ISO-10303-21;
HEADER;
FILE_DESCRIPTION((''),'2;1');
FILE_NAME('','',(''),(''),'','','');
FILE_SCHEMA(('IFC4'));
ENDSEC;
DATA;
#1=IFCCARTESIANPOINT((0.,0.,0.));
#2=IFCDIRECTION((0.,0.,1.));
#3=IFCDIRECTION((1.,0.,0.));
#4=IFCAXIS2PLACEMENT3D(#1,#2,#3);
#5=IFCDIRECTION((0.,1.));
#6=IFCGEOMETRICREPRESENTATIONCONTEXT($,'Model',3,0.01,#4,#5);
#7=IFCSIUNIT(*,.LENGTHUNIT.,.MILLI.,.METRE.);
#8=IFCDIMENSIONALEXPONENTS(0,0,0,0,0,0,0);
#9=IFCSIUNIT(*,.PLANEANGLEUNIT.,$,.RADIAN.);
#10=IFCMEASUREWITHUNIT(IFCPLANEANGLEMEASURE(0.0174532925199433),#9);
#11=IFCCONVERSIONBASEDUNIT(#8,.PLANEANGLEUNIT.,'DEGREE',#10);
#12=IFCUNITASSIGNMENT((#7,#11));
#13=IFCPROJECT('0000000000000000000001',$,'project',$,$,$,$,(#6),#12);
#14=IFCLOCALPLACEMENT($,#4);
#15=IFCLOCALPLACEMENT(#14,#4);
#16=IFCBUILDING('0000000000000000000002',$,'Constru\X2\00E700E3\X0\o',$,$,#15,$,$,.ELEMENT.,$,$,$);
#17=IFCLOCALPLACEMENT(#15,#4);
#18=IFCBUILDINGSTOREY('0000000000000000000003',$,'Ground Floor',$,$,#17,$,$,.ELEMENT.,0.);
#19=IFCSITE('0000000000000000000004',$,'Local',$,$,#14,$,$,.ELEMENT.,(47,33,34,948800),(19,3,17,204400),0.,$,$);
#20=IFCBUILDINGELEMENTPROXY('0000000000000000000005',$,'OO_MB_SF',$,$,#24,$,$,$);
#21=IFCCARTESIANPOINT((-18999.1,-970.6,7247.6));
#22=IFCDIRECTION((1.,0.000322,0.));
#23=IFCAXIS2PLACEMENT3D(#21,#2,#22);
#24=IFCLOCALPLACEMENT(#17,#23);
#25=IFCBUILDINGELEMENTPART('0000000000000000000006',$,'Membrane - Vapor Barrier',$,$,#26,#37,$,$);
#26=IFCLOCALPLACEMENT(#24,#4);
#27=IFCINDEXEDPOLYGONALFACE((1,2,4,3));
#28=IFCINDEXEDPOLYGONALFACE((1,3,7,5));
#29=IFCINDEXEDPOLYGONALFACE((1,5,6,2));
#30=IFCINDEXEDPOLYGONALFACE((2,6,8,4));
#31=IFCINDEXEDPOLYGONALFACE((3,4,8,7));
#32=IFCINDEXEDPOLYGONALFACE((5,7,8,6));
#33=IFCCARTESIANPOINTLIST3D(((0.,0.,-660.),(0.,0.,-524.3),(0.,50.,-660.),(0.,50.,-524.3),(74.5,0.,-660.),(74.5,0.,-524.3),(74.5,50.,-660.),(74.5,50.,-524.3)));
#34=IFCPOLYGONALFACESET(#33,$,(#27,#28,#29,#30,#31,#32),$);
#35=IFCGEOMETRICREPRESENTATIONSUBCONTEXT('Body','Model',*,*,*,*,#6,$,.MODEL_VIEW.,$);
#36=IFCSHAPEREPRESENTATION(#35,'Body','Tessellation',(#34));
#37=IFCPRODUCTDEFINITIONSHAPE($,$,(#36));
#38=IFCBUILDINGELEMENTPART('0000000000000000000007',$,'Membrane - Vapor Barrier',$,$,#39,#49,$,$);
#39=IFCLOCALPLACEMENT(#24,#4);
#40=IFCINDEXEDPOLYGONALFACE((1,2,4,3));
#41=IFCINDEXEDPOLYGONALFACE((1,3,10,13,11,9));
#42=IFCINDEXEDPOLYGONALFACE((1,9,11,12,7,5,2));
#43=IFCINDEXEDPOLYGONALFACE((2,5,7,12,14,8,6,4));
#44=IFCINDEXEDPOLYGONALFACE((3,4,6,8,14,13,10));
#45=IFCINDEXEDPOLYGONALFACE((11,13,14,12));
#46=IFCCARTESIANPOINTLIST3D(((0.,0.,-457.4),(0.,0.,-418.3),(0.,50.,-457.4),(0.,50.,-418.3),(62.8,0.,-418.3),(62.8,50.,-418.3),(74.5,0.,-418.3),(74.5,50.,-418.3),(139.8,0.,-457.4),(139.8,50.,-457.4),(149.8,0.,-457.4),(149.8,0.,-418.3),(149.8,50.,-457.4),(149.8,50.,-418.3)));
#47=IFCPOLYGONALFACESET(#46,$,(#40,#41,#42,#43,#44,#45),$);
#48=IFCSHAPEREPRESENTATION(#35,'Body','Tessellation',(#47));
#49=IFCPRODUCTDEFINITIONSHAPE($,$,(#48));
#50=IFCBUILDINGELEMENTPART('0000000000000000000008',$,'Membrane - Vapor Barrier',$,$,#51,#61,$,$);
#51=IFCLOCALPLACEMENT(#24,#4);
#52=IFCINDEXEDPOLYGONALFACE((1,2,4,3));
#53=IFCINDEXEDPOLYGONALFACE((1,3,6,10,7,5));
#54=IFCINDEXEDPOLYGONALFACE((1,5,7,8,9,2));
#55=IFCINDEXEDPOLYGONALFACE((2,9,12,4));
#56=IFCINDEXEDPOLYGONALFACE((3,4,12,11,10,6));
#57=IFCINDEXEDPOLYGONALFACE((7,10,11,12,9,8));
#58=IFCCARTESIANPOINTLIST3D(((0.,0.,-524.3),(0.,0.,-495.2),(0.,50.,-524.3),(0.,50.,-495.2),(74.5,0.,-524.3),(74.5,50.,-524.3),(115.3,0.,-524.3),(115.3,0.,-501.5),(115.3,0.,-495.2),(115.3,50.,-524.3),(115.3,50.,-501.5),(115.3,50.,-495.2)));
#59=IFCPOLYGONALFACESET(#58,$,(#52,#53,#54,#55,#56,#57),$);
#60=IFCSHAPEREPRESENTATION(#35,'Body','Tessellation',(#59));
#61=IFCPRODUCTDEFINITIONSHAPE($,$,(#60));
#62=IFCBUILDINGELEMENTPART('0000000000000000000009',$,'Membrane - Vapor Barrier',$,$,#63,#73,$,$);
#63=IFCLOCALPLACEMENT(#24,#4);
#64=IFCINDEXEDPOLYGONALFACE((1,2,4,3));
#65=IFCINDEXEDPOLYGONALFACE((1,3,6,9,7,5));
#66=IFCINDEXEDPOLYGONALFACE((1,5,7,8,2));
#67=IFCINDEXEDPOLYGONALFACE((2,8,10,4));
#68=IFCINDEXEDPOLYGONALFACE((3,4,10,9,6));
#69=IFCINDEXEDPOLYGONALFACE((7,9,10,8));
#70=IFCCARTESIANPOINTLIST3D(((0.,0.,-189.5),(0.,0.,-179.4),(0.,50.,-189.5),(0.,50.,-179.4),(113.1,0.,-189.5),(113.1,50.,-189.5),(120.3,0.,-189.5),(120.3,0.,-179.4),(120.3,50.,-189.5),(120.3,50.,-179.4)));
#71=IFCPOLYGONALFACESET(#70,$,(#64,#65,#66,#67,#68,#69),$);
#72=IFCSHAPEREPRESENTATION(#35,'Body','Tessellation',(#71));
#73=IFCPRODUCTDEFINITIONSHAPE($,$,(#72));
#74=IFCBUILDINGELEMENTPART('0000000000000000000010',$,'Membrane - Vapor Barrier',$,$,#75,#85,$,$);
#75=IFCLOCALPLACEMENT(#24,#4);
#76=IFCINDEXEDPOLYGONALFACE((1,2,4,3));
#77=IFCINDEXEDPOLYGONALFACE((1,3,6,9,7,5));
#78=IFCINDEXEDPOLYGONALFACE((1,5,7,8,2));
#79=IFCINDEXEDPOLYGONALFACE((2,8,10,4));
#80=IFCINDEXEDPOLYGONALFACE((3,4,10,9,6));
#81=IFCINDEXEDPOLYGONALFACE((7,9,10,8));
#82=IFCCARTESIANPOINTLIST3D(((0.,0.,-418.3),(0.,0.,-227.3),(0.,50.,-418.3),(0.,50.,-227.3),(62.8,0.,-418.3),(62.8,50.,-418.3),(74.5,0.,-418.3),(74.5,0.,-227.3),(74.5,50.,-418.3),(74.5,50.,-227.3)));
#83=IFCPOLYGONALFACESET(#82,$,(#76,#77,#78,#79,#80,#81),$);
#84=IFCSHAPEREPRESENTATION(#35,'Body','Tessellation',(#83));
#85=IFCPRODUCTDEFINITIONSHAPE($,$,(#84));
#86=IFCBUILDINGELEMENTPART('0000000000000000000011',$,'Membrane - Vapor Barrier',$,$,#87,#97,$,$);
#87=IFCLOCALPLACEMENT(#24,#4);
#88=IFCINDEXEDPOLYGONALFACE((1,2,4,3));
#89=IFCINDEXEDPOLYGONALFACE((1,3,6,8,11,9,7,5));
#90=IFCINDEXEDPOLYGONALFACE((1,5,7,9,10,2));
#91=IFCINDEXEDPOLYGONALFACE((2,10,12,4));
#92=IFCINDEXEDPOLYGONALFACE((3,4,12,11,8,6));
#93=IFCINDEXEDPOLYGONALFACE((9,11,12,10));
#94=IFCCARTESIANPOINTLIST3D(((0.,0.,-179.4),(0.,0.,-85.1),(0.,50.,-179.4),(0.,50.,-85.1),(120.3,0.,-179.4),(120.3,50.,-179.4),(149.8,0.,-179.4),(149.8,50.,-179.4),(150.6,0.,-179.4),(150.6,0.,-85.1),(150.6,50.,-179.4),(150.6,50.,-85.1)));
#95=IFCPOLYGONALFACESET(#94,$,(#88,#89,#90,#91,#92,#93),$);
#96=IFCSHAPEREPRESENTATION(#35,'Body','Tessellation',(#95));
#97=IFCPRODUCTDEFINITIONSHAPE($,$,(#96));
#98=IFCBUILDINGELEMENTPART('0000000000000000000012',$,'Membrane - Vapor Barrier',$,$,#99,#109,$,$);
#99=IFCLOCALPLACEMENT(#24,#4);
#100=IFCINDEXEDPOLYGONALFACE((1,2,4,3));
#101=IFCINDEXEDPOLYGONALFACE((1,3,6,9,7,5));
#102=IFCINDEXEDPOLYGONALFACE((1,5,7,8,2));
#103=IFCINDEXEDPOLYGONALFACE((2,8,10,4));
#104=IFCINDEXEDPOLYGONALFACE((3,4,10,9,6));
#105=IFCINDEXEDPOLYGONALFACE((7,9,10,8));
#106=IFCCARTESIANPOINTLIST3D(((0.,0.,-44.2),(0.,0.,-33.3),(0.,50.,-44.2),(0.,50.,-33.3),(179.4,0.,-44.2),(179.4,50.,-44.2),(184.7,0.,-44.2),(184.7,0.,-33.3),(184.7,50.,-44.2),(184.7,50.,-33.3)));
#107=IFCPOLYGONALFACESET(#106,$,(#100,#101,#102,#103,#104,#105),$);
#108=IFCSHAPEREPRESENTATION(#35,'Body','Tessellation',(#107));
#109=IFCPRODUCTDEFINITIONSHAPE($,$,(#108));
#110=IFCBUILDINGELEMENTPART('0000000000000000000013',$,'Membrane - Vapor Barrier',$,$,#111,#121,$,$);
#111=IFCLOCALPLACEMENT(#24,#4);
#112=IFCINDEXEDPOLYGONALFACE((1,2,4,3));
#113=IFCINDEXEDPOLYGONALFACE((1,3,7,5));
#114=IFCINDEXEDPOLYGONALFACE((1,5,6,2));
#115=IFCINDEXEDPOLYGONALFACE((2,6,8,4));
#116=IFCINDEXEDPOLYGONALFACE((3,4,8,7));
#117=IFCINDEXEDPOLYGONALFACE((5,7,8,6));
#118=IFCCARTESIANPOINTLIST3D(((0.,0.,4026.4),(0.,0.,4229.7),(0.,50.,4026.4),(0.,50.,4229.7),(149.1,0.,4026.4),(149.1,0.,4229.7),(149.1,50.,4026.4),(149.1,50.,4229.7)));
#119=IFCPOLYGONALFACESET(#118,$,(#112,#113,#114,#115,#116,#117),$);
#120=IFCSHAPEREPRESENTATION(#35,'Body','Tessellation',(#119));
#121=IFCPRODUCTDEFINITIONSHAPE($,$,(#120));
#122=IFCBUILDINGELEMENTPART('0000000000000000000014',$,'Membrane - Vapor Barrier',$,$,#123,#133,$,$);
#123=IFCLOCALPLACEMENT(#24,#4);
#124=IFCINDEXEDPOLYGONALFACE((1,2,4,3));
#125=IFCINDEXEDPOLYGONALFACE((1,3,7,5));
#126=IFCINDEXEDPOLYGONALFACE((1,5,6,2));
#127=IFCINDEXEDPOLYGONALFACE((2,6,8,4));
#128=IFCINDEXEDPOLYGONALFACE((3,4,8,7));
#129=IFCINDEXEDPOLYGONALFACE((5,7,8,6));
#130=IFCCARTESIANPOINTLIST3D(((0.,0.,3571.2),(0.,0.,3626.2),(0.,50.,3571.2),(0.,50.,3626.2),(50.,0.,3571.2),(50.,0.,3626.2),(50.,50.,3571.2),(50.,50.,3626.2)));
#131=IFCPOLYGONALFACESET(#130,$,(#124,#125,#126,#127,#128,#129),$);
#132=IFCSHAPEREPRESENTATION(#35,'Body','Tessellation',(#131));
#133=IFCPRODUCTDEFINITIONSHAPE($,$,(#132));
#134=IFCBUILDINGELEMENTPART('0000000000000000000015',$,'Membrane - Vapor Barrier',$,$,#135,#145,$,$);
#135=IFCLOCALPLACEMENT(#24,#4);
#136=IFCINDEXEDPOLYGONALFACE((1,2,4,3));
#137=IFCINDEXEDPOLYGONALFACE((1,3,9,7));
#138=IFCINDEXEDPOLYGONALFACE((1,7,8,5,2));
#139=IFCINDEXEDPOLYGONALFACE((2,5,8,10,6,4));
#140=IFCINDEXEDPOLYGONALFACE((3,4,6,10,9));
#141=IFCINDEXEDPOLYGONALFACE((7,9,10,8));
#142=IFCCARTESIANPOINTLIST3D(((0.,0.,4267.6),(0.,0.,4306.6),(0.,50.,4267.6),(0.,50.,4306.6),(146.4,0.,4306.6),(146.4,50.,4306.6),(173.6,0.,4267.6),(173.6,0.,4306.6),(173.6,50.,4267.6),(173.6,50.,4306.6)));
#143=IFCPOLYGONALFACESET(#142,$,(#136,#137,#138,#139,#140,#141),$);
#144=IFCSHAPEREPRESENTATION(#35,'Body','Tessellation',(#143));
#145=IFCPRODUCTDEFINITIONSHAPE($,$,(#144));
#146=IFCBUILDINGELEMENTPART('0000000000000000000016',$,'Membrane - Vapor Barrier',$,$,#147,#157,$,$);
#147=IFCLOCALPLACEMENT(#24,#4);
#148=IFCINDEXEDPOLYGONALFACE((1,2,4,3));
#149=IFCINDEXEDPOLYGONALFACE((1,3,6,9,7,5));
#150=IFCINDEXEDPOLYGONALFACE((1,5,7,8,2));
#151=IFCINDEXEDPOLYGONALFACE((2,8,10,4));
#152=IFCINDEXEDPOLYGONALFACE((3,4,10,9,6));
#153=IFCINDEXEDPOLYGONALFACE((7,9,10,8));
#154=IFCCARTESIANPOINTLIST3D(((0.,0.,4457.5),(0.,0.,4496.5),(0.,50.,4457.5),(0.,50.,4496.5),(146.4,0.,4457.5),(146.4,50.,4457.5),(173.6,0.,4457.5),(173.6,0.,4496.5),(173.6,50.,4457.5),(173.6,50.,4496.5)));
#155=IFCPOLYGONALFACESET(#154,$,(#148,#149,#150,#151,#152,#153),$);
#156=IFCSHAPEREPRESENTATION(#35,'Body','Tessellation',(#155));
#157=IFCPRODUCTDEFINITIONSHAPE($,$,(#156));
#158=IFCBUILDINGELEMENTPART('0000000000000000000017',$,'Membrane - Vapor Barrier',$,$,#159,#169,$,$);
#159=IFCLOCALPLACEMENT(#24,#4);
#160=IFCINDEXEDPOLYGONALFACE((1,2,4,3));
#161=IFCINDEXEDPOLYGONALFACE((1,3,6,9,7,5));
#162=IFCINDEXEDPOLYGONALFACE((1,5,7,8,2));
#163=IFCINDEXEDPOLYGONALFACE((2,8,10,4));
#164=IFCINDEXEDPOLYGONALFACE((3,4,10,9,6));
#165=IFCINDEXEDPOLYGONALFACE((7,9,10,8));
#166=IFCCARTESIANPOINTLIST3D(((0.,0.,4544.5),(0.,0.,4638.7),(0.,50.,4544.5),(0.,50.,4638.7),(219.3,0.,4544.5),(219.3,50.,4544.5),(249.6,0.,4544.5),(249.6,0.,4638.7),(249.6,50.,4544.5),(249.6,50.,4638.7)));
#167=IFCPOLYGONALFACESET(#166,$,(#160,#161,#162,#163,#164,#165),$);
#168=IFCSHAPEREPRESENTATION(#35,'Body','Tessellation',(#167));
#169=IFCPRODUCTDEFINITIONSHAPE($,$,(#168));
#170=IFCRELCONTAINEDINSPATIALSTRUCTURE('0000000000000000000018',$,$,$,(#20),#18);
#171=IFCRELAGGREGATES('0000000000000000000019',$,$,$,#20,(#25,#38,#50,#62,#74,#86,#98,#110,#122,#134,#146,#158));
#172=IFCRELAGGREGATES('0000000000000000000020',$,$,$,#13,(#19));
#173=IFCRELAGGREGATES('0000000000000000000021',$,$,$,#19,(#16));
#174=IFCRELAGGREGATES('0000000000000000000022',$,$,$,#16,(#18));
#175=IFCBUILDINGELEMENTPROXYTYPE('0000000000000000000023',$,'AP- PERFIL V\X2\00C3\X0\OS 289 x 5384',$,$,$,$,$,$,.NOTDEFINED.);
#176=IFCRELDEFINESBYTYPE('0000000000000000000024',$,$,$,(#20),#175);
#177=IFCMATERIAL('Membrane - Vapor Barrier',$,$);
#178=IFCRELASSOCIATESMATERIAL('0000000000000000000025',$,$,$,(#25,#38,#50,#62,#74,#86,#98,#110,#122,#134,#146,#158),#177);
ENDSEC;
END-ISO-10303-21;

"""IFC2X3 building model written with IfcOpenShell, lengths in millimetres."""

from ifc_helpers import new_model, entity, si_unit, converted_unit, direction, frame, origin_with_axes, place, context, subcontext, project, spatial, polyline, outline, extrude, material, type_object, element, aggregate, save


model = new_model("IFC2X3")

# Units and contexts
model_context = context("Model", 3, precision=0.01, world=origin_with_axes(), true_north=direction((0.0, 1.0)))
body_context = subcontext(model_context, "Body", "Model", "MODEL_VIEW")
ifc_project = project(units=[si_unit("LENGTHUNIT", "METRE", prefix="MILLI"), converted_unit("PLANEANGLEUNIT", "DEGREE", entity("IfcPlaneAngleMeasure", 0.0174532925199433), si_unit("PLANEANGLEUNIT", "RADIAN"), dimensions=[0, 0, 0, 0, 0, 0, 0])], contexts=[model_context])

# Site, building, storey
site_placement = place(None, origin_with_axes())
site = spatial("IfcSite", under=ifc_project, at=site_placement, Name="Local", CompositionType="ELEMENT", RefLatitude=(47, 33, 34, 948800), RefLongitude=(19, 3, 17, 204400), RefElevation=0.0)
building_placement = place(site_placement, origin_with_axes())
building = spatial("IfcBuilding", under=site, at=building_placement, Name="Construção", CompositionType="ELEMENT")
storey_placement = place(building_placement, origin_with_axes())
storey = spatial("IfcBuildingStorey", under=building, at=storey_placement, Name="Ground Floor", CompositionType="ELEMENT", Elevation=0.0)

# Building element proxy, building element parts
building_element_proxy_type = type_object("IfcBuildingElementProxyType", Name="AP- PERFIL VÃOS 289 x 5384", PredefinedType="NOTDEFINED")
proxy_1_placement = place(storey_placement, frame((-18999.1, -970.6, 7247.6), z_axis=(0.0, 0.0, 1.0), x_axis=(1.0, 0.000322, 0.0)))
proxy_1 = element("IfcBuildingElementProxy", 1, at=proxy_1_placement, inside=storey, type_object=building_element_proxy_type, Name="OO_MB_SF")
ifc_material = material(Name="Membrane - Vapor Barrier")
building_element_part_1_placement = place(proxy_1_placement, origin_with_axes())
building_element_part_1 = element("IfcBuildingElementPart", 2, at=building_element_part_1_placement, material=ifc_material, Name="Membrane - Vapor Barrier", context=body_context, shape_type="SweptSolid", body=[
    extrude(outline(polyline([(0.0, -660.0), (74.5, -660.0), (74.5, -524.3), (0.0, -524.3), (0.0, -660.0)])), frame((0.0, 50.0, 0.0), z_axis=(0.0, -1.0, 0.0), x_axis=(1.0, 0.0, 0.0)), (0.0, 0.0, 1.0), 50.0),
])
building_element_part_2_placement = place(proxy_1_placement, origin_with_axes())
building_element_part_2 = element("IfcBuildingElementPart", 3, at=building_element_part_2_placement, material=ifc_material, Name="Membrane - Vapor Barrier", context=body_context, shape_type="SweptSolid", body=[
    extrude(outline(polyline([(62.8, -418.3), (0.0, -418.3), (0.0, -457.4), (139.8, -457.4), (149.8, -457.4), (149.8, -418.3), (74.5, -418.3), (62.8, -418.3)])), frame((0.0, 50.0, 0.0), z_axis=(0.0, -1.0, 0.0), x_axis=(1.0, 0.0, 0.0)), (0.0, 0.0, 1.0), 50.0),
])
building_element_part_3_placement = place(proxy_1_placement, origin_with_axes())
building_element_part_3 = element("IfcBuildingElementPart", 4, at=building_element_part_3_placement, material=ifc_material, Name="Membrane - Vapor Barrier", context=body_context, shape_type="SweptSolid", body=[
    extrude(outline(polyline([(0.0, -524.3), (74.5, -524.3), (115.3, -524.3), (115.3, -501.5), (115.3, -495.2), (0.0, -495.2), (0.0, -524.3)])), frame((0.0, 50.0, 0.0), z_axis=(0.0, -1.0, 0.0), x_axis=(1.0, 0.0, 0.0)), (0.0, 0.0, 1.0), 50.0),
])
building_element_part_4_placement = place(proxy_1_placement, origin_with_axes())
building_element_part_4 = element("IfcBuildingElementPart", 5, at=building_element_part_4_placement, material=ifc_material, Name="Membrane - Vapor Barrier", context=body_context, shape_type="SweptSolid", body=[
    extrude(outline(polyline([(120.3, -179.4), (0.0, -179.4), (0.0, -189.5), (113.1, -189.5), (120.3, -189.5), (120.3, -179.4)])), frame((0.0, 50.0, 0.0), z_axis=(0.0, -1.0, 0.0), x_axis=(1.0, 0.0, 0.0)), (0.0, 0.0, 1.0), 50.0),
])
building_element_part_5_placement = place(proxy_1_placement, origin_with_axes())
building_element_part_5 = element("IfcBuildingElementPart", 6, at=building_element_part_5_placement, material=ifc_material, Name="Membrane - Vapor Barrier", context=body_context, shape_type="SweptSolid", body=[
    extrude(outline(polyline([(0.0, -227.3), (0.0, -418.3), (62.8, -418.3), (74.5, -418.3), (74.5, -227.3), (0.0, -227.3)])), frame((0.0, 50.0, 0.0), z_axis=(0.0, -1.0, 0.0), x_axis=(1.0, 0.0, 0.0)), (0.0, 0.0, 1.0), 50.0),
])
building_element_part_6_placement = place(proxy_1_placement, origin_with_axes())
building_element_part_6 = element("IfcBuildingElementPart", 7, at=building_element_part_6_placement, material=ifc_material, Name="Membrane - Vapor Barrier", context=body_context, shape_type="SweptSolid", body=[
    extrude(outline(polyline([(0.0, -85.1), (0.0, -179.4), (120.3, -179.4), (149.8, -179.4), (150.6, -179.4), (150.6, -85.1), (0.0, -85.1)])), frame((0.0, 50.0, 0.0), z_axis=(0.0, -1.0, 0.0), x_axis=(1.0, 0.0, 0.0)), (0.0, 0.0, 1.0), 50.0),
])
building_element_part_7_placement = place(proxy_1_placement, origin_with_axes())
building_element_part_7 = element("IfcBuildingElementPart", 8, at=building_element_part_7_placement, material=ifc_material, Name="Membrane - Vapor Barrier", context=body_context, shape_type="SweptSolid", body=[
    extrude(outline(polyline([(184.7, -33.3), (0.0, -33.3), (0.0, -44.2), (179.4, -44.2), (184.7, -44.2), (184.7, -33.3)])), frame((0.0, 50.0, 0.0), z_axis=(0.0, -1.0, 0.0), x_axis=(1.0, 0.0, 0.0)), (0.0, 0.0, 1.0), 50.0),
])
building_element_part_8_placement = place(proxy_1_placement, origin_with_axes())
building_element_part_8 = element("IfcBuildingElementPart", 9, at=building_element_part_8_placement, material=ifc_material, Name="Membrane - Vapor Barrier", context=body_context, shape_type="SweptSolid", body=[
    extrude(outline(polyline([(149.1, 4229.7), (0.0, 4229.7), (0.0, 4026.4), (149.1, 4026.4), (149.1, 4229.7)])), frame((0.0, 50.0, 0.0), z_axis=(0.0, -1.0, 0.0), x_axis=(1.0, 0.0, 0.0)), (0.0, 0.0, 1.0), 50.0),
])
building_element_part_9_placement = place(proxy_1_placement, origin_with_axes())
building_element_part_9 = element("IfcBuildingElementPart", 10, at=building_element_part_9_placement, material=ifc_material, Name="Membrane - Vapor Barrier", context=body_context, shape_type="SweptSolid", body=[
    extrude(outline(polyline([(0.0, 3571.2), (50.0, 3571.2), (50.0, 3626.2), (0.0, 3626.2), (0.0, 3571.2)])), frame((0.0, 50.0, 0.0), z_axis=(0.0, -1.0, 0.0), x_axis=(1.0, 0.0, 0.0)), (0.0, 0.0, 1.0), 50.0),
])
building_element_part_10_placement = place(proxy_1_placement, origin_with_axes())
building_element_part_10 = element("IfcBuildingElementPart", 11, at=building_element_part_10_placement, material=ifc_material, Name="Membrane - Vapor Barrier", context=body_context, shape_type="SweptSolid", body=[
    extrude(outline(polyline([(0.0, 4306.6), (0.0, 4267.6), (173.6, 4267.6), (173.6, 4306.6), (146.4, 4306.6), (0.0, 4306.6)])), frame((0.0, 50.0, 0.0), z_axis=(0.0, -1.0, 0.0), x_axis=(1.0, 0.0, 0.0)), (0.0, 0.0, 1.0), 50.0),
])
building_element_part_11_placement = place(proxy_1_placement, origin_with_axes())
building_element_part_11 = element("IfcBuildingElementPart", 12, at=building_element_part_11_placement, material=ifc_material, Name="Membrane - Vapor Barrier", context=body_context, shape_type="SweptSolid", body=[
    extrude(outline(polyline([(173.6, 4496.5), (0.0, 4496.5), (0.0, 4457.5), (146.4, 4457.5), (173.6, 4457.5), (173.6, 4496.5)])), frame((0.0, 50.0, 0.0), z_axis=(0.0, -1.0, 0.0), x_axis=(1.0, 0.0, 0.0)), (0.0, 0.0, 1.0), 50.0),
])
building_element_part_12_placement = place(proxy_1_placement, origin_with_axes())
building_element_part_12 = element("IfcBuildingElementPart", 13, at=building_element_part_12_placement, material=ifc_material, Name="Membrane - Vapor Barrier", context=body_context, shape_type="SweptSolid", body=[
    extrude(outline(polyline([(249.6, 4638.7), (0.0, 4638.7), (0.0, 4544.5), (219.3, 4544.5), (249.6, 4544.5), (249.6, 4638.7)])), frame((0.0, 50.0, 0.0), z_axis=(0.0, -1.0, 0.0), x_axis=(1.0, 0.0, 0.0)), (0.0, 0.0, 1.0), 50.0),
])
aggregate(proxy_1, [building_element_part_1, building_element_part_2, building_element_part_3, building_element_part_4, building_element_part_5, building_element_part_6, building_element_part_7, building_element_part_8, building_element_part_9, building_element_part_10, building_element_part_11, building_element_part_12])

save(model, "model.ifc")
